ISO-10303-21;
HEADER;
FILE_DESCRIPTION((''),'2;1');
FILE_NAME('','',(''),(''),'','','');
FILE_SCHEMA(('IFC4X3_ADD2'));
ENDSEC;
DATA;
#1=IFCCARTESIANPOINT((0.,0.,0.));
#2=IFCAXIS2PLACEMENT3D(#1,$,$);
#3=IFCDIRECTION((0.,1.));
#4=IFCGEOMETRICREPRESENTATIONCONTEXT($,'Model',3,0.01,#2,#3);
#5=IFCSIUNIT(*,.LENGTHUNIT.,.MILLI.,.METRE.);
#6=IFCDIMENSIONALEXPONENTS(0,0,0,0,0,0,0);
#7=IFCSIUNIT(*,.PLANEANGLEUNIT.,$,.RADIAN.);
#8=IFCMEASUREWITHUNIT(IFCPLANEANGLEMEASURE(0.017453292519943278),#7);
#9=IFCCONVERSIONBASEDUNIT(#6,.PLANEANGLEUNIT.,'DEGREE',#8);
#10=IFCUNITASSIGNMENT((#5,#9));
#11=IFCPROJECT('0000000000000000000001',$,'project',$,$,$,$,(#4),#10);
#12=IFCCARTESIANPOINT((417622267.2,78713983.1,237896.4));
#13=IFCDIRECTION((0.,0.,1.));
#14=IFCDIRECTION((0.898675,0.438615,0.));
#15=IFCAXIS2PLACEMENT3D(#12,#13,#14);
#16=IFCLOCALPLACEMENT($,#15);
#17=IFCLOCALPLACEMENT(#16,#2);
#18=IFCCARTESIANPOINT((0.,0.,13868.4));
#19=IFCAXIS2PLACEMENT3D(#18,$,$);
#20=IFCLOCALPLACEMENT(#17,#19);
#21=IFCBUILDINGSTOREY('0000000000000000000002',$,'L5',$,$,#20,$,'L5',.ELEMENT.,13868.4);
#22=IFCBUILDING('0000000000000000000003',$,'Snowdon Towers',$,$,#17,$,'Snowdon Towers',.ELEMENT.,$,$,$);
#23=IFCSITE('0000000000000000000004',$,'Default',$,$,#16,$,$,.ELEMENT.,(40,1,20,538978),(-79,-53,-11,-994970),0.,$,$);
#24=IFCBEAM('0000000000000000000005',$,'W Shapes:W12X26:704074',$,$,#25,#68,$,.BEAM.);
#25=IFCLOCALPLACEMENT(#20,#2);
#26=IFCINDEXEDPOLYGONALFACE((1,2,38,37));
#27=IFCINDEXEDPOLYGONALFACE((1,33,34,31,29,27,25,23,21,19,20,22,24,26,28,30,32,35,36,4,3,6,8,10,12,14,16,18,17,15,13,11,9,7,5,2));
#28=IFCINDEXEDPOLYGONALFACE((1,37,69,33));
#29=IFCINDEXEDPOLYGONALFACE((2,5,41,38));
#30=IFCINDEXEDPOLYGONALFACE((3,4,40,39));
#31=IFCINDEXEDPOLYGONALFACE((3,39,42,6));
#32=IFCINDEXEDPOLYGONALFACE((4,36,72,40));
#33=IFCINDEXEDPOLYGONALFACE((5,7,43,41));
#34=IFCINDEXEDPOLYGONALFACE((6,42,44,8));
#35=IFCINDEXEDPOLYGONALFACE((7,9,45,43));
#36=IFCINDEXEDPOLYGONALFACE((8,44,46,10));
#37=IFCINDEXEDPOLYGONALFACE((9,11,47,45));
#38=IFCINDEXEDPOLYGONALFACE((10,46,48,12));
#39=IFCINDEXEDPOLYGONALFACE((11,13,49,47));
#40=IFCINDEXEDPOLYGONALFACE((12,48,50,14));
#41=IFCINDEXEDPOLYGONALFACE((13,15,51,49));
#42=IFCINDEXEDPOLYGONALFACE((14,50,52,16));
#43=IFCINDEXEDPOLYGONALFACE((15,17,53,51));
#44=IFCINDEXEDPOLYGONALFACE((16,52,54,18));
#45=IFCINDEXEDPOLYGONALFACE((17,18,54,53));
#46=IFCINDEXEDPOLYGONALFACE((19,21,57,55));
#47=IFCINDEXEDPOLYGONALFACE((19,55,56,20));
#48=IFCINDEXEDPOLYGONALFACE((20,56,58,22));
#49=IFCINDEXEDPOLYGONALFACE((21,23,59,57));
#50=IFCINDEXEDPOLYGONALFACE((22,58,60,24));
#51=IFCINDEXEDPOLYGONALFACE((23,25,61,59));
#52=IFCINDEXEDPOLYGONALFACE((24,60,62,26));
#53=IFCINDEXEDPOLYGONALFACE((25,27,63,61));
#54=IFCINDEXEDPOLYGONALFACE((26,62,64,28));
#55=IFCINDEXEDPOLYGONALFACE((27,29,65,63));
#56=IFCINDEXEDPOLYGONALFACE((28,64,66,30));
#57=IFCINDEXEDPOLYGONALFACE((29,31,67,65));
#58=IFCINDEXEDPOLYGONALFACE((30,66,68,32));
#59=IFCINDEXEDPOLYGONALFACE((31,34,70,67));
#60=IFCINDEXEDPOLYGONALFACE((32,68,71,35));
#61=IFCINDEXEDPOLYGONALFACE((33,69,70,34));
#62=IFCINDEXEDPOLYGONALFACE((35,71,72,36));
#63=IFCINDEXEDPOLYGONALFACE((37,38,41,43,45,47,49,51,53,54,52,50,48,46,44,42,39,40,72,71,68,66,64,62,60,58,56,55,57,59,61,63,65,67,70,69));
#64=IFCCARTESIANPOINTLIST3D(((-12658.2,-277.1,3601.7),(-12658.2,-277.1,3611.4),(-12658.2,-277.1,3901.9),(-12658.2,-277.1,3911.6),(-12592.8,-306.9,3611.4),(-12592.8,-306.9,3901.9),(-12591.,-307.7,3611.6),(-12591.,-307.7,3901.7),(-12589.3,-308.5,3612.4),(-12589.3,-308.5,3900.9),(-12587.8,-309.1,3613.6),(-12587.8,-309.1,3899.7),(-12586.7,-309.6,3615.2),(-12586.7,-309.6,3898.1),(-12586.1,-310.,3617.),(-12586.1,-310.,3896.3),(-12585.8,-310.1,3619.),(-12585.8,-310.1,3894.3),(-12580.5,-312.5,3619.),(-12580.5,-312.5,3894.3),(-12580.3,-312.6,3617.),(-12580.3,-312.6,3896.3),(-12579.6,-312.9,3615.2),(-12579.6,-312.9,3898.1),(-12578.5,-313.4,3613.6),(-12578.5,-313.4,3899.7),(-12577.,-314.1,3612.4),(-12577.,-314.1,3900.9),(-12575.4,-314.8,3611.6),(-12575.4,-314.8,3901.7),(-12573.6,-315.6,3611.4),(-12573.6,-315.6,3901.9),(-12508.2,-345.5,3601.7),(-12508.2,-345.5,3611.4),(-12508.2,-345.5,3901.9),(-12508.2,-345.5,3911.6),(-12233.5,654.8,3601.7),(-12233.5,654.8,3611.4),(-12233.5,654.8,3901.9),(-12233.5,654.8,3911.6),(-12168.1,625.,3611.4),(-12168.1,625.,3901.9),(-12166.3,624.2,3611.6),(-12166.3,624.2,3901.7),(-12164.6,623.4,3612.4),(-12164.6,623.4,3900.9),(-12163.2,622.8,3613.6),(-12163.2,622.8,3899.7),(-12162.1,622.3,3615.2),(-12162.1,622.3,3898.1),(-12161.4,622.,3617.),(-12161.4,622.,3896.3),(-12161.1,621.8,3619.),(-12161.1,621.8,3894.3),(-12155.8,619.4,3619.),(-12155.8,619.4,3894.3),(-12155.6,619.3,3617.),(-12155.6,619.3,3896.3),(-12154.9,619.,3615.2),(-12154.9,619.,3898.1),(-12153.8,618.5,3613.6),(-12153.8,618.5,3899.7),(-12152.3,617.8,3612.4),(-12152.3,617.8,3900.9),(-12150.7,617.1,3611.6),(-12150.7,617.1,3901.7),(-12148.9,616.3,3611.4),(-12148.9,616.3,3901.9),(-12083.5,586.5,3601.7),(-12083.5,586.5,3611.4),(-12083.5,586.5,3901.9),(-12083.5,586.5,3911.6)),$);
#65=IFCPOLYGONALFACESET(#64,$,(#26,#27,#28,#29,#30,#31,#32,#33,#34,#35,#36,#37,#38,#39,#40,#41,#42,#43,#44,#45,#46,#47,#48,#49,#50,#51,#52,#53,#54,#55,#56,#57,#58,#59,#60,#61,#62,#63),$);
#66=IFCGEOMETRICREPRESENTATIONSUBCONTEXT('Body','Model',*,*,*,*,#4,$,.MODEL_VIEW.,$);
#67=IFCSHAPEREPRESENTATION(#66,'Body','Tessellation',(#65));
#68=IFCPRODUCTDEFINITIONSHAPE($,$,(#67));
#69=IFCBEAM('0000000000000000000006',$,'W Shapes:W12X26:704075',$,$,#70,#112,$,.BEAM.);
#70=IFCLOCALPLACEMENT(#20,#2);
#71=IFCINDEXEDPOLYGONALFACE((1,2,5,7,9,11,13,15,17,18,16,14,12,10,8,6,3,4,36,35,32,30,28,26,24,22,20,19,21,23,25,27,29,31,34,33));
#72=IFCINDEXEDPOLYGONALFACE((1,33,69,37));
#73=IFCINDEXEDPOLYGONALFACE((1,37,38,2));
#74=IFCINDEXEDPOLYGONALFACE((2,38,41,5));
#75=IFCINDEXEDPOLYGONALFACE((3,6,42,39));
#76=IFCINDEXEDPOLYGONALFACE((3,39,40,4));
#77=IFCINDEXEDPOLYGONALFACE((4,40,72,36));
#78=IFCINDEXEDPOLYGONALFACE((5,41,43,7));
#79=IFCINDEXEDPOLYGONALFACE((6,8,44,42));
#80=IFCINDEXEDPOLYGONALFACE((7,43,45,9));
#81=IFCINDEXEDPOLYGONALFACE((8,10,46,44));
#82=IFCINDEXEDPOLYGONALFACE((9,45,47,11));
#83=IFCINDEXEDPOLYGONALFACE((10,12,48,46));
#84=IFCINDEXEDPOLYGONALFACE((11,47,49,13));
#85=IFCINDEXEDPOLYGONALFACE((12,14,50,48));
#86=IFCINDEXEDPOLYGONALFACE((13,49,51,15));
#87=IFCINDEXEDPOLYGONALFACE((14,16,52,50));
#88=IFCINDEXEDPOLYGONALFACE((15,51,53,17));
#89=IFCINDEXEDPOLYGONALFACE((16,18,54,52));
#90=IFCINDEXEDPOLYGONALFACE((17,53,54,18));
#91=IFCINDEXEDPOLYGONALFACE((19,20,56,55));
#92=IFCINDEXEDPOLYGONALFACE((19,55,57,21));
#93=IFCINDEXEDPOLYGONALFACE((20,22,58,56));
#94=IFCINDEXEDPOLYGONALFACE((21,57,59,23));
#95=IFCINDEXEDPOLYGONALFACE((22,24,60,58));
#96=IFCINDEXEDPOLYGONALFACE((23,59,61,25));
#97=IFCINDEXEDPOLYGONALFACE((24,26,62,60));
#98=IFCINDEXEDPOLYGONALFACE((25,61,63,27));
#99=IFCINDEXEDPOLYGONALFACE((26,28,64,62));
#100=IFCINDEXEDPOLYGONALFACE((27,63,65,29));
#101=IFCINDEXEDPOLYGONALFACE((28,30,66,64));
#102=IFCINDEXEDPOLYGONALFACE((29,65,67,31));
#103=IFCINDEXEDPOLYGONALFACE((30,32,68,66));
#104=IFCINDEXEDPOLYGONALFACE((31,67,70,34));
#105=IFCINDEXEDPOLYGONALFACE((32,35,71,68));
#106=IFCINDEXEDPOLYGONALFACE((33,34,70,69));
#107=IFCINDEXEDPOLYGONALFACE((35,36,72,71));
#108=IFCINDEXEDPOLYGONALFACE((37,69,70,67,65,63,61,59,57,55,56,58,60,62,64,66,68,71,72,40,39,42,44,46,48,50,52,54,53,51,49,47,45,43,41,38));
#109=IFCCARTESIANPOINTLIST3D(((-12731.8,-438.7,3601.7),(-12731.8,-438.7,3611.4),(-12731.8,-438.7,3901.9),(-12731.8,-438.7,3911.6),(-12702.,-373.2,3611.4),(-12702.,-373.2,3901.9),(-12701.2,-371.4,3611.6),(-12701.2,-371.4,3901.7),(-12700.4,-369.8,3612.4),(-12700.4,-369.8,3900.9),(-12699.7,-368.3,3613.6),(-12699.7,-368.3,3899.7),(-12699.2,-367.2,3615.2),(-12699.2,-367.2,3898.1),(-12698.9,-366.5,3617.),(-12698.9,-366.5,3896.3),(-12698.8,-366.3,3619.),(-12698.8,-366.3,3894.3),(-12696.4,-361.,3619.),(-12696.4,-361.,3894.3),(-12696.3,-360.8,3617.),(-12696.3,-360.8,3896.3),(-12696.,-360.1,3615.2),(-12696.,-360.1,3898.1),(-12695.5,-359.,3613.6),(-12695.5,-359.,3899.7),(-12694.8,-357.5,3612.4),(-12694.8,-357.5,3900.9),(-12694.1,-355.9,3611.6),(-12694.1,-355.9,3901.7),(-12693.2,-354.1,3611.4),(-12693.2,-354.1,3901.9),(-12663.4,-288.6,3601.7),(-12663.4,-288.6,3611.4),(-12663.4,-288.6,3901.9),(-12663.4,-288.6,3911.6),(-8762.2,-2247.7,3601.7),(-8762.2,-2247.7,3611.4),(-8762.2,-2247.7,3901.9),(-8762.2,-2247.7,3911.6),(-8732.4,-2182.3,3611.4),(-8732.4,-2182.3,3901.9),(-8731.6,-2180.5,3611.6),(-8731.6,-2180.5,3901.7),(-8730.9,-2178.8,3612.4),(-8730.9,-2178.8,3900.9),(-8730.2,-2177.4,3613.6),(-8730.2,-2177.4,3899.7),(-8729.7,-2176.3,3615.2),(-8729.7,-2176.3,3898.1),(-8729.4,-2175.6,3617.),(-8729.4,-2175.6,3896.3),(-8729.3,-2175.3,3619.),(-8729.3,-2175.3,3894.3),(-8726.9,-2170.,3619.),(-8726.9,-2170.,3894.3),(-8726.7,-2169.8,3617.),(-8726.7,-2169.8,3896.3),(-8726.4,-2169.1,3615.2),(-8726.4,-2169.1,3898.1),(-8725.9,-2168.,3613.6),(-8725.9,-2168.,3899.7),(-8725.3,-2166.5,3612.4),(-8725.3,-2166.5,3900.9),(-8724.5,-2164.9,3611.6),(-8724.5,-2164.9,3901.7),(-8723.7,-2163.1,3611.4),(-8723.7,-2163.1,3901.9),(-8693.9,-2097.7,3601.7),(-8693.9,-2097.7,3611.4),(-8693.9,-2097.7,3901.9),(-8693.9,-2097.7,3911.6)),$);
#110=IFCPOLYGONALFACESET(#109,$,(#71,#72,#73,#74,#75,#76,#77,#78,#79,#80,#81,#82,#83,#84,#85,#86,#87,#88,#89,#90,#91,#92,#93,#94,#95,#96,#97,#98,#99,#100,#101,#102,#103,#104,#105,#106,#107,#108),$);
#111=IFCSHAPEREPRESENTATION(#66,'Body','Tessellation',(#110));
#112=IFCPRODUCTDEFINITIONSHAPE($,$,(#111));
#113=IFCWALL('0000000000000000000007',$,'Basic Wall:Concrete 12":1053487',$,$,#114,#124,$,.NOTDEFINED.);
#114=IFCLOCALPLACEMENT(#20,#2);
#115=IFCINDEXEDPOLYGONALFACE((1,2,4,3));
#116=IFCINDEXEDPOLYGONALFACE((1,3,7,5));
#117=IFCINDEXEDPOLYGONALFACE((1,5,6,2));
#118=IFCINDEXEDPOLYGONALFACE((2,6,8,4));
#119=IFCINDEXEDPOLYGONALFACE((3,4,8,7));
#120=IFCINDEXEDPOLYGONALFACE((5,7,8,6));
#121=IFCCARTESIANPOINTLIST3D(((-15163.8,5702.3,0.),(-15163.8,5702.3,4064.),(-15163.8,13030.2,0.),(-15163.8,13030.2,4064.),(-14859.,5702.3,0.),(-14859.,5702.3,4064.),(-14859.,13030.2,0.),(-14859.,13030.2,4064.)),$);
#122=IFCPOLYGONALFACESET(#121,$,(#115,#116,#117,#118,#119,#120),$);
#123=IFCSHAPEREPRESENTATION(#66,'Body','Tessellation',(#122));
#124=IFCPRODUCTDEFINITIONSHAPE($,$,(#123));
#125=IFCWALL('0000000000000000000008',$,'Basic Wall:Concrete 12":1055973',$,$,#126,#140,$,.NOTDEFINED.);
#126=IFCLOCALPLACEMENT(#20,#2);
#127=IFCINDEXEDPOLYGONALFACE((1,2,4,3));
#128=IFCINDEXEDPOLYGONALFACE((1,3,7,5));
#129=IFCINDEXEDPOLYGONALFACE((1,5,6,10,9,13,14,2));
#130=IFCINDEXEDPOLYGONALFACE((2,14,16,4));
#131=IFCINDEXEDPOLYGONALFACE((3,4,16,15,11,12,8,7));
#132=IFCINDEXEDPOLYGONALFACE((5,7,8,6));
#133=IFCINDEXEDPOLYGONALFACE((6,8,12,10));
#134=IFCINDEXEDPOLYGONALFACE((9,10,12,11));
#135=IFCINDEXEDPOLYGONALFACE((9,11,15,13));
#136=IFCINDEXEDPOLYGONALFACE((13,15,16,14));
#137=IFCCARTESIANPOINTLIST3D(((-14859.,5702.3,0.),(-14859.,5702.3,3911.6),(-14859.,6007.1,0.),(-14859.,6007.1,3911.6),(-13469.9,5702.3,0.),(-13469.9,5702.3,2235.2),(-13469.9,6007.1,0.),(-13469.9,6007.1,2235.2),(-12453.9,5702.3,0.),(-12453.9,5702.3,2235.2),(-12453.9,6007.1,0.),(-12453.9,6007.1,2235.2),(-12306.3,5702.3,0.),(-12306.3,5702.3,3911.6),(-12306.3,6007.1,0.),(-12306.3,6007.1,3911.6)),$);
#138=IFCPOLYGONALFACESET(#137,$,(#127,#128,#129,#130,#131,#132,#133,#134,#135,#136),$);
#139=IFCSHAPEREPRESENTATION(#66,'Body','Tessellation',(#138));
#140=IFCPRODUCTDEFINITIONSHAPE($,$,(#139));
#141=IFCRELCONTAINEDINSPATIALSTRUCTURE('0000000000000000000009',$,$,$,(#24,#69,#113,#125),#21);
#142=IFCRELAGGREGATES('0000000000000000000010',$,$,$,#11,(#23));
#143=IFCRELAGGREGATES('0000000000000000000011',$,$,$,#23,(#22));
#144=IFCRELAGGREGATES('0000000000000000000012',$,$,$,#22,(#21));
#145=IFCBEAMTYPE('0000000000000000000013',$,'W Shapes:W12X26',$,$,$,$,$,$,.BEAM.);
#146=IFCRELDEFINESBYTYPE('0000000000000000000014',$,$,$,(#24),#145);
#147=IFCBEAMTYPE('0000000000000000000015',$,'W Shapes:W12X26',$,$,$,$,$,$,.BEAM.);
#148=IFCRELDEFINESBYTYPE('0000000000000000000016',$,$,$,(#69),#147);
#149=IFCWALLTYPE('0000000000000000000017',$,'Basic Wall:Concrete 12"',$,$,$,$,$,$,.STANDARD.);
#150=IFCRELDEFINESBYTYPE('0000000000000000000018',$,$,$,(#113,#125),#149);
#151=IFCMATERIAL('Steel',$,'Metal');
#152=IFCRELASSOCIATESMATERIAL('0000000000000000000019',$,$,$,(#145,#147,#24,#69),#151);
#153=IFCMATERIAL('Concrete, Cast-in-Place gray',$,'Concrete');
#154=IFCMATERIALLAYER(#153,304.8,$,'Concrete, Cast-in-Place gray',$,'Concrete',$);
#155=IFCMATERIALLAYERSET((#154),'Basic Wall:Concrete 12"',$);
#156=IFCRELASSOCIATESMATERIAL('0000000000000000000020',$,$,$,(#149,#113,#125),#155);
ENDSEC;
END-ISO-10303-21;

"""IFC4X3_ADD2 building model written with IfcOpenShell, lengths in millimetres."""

from ifc_helpers import new_model, entity, si_unit, converted_unit, direction, frame, frame_2d, origin, place, context, subcontext, project, spatial, polyline, circle_curve, parameter, trimmed, segment, composite_curve, rectangle, outline, extrude, source, transform, mapped, material, layer, layer_set, material_profile, profile_set, profile_usage, type_object, type_shapes, element, save


model = new_model("IFC4X3_ADD2")

# Units and contexts
model_context = context("Model", 3, precision=0.01, world=origin(), true_north=direction((0.0, 1.0)))
body_context = subcontext(model_context, "Body", "Model", "MODEL_VIEW")
ifc_project = project(units=[si_unit("LENGTHUNIT", "METRE", prefix="MILLI"), converted_unit("PLANEANGLEUNIT", "DEGREE", entity("IfcPlaneAngleMeasure", 0.017453292519943278), si_unit("PLANEANGLEUNIT", "RADIAN"), dimensions=[0, 0, 0, 0, 0, 0, 0])], contexts=[model_context])

# Site, building, storey
site_placement = place(None, frame((417622267.2, 78713983.1, 237896.4), z_axis=(0.0, 0.0, 1.0), x_axis=(0.898675, 0.438615, 0.0)))
site = spatial("IfcSite", under=ifc_project, at=site_placement, Name="Default", CompositionType="ELEMENT", RefLatitude=(40, 1, 20, 538978), RefLongitude=(-79, -53, -11, -994970), RefElevation=0.0)
building_placement = place(site_placement, origin())
building = spatial("IfcBuilding", under=site, at=building_placement, Name="Snowdon Towers", LongName="Snowdon Towers", CompositionType="ELEMENT")
storey_placement = place(building_placement, frame((0.0, 0.0, 13868.4)))
storey = spatial("IfcBuildingStorey", under=building, at=storey_placement, Name="L5", LongName="L5", CompositionType="ELEMENT", Elevation=13868.4)

# Beams
ifc_material_1 = material(Name="Steel", Category="Metal")
ifc_material_profile_1 = material_profile(ifc_material_1, outline(composite_curve([segment(polyline([(-82.4, -145.3), (-82.4, -154.9)]), True, "CONTINUOUS"), segment(polyline([(-82.4, -154.9), (82.4, -154.9)]), True, "CONTINUOUS"), segment(polyline([(82.4, -154.9), (82.4, -145.3)]), True, "CONTINUOUS"), segment(polyline([(82.4, -145.3), (10.5, -145.3)]), True, "CONTINUOUS"), segment(trimmed(circle_curve(frame_2d((10.5, -137.7), x_axis=(1.0, 0.0)), 7.6), [parameter(180.0)], [parameter(270.0)], True, "PARAMETER"), False, "CONTINUOUS"), segment(polyline([(2.9, -137.7), (2.9, 137.7)]), True, "CONTINUOUS"), segment(trimmed(circle_curve(frame_2d((10.5, 137.7), x_axis=(1.0, 0.0)), 7.6), [parameter(90.0)], [parameter(180.0)], True, "PARAMETER"), False, "CONTINUOUS"), segment(polyline([(10.5, 145.3), (82.4, 145.3)]), True, "CONTINUOUS"), segment(polyline([(82.4, 145.3), (82.4, 154.9)]), True, "CONTINUOUS"), segment(polyline([(82.4, 154.9), (-82.4, 154.9)]), True, "CONTINUOUS"), segment(polyline([(-82.4, 154.9), (-82.4, 145.3)]), True, "CONTINUOUS"), segment(polyline([(-82.4, 145.3), (-10.5, 145.3)]), True, "CONTINUOUS"), segment(trimmed(circle_curve(frame_2d((-10.5, 137.7), x_axis=(1.0, 0.0)), 7.6), [parameter(360.0)], [parameter(90.0)], True, "PARAMETER"), False, "CONTINUOUS"), segment(polyline([(-2.9, 137.7), (-2.9, -137.7)]), True, "CONTINUOUS"), segment(trimmed(circle_curve(frame_2d((-10.5, -137.7), x_axis=(1.0, 0.0)), 7.6), [parameter(270.0)], [parameter(360.0)], True, "PARAMETER"), False, "CONTINUOUS"), segment(polyline([(-10.5, -145.3), (-82.4, -145.3)]), True, "CONTINUOUS")], self_intersect=False)), Name="W12X26")
ifc_profile_set_1 = profile_set([ifc_material_profile_1], Name="W12X26")
ifc_profile_usage_1 = profile_usage(ifc_profile_set_1, cardinal=8)
beam_type_1 = type_object("IfcBeamType", Name="W Shapes:W12X26", PredefinedType="BEAM", material=ifc_profile_set_1)
shared_shape_1 = source(origin(), body_context, "Body", "SweptSolid", [
    extrude(outline(composite_curve([segment(polyline([(-82.4, -145.3), (-82.4, -154.9)]), True, "CONTINUOUS"), segment(polyline([(-82.4, -154.9), (82.4, -154.9)]), True, "CONTINUOUS"), segment(polyline([(82.4, -154.9), (82.4, -145.3)]), True, "CONTINUOUS"), segment(polyline([(82.4, -145.3), (10.5, -145.3)]), True, "CONTINUOUS"), segment(trimmed(circle_curve(frame_2d((10.5, -137.7), x_axis=(1.0, 0.0)), 7.6), [parameter(180.0)], [parameter(270.0)], True, "PARAMETER"), False, "CONTINUOUS"), segment(polyline([(2.9, -137.7), (2.9, 137.7)]), True, "CONTINUOUS"), segment(trimmed(circle_curve(frame_2d((10.5, 137.7), x_axis=(1.0, 0.0)), 7.6), [parameter(90.0)], [parameter(180.0)], True, "PARAMETER"), False, "CONTINUOUS"), segment(polyline([(10.5, 145.3), (82.4, 145.3)]), True, "CONTINUOUS"), segment(polyline([(82.4, 145.3), (82.4, 154.9)]), True, "CONTINUOUS"), segment(polyline([(82.4, 154.9), (-82.4, 154.9)]), True, "CONTINUOUS"), segment(polyline([(-82.4, 154.9), (-82.4, 145.3)]), True, "CONTINUOUS"), segment(polyline([(-82.4, 145.3), (-10.5, 145.3)]), True, "CONTINUOUS"), segment(trimmed(circle_curve(frame_2d((-10.5, 137.7), x_axis=(1.0, 0.0)), 7.6), [parameter(360.0)], [parameter(90.0)], True, "PARAMETER"), False, "CONTINUOUS"), segment(polyline([(-2.9, 137.7), (-2.9, -137.7)]), True, "CONTINUOUS"), segment(trimmed(circle_curve(frame_2d((-10.5, -137.7), x_axis=(1.0, 0.0)), 7.6), [parameter(270.0)], [parameter(360.0)], True, "PARAMETER"), False, "CONTINUOUS"), segment(polyline([(-10.5, -145.3), (-82.4, -145.3)]), True, "CONTINUOUS")], self_intersect=False)), frame((-542.2, 0.0, 0.0), z_axis=(-1.0, 0.0, 0.0), x_axis=(0.0, -1.0, 0.0)), (0.0, 0.0, -1.0), 1024.1),
])
type_shapes(beam_type_1, [shared_shape_1])
beam_1_placement = place(storey_placement, frame((-12358.3, 182.1, 3756.7), z_axis=(0.0, 0.0, 1.0), x_axis=(0.414693, 0.909961, 0.0)))
element("IfcBeam", 1, at=beam_1_placement, inside=storey, type_object=beam_type_1, material=ifc_profile_usage_1, Name="W Shapes:W12X26:704074", PredefinedType="BEAM", context=body_context, shape_type="MappedRepresentation", body=[
    mapped(shared_shape_1, transform((0.0, 0.0, 0.0), scale=1.0)),
])
beam_type_2 = type_object("IfcBeamType", Name="W Shapes:W12X26", PredefinedType="BEAM", material=ifc_profile_set_1)
shared_shape_2 = source(origin(), body_context, "Body", "SweptSolid", [
    extrude(outline(composite_curve([segment(polyline([(-82.4, -145.3), (-82.4, -154.9)]), True, "CONTINUOUS"), segment(polyline([(-82.4, -154.9), (82.4, -154.9)]), True, "CONTINUOUS"), segment(polyline([(82.4, -154.9), (82.4, -145.3)]), True, "CONTINUOUS"), segment(polyline([(82.4, -145.3), (10.5, -145.3)]), True, "CONTINUOUS"), segment(trimmed(circle_curve(frame_2d((10.5, -137.7), x_axis=(1.0, 0.0)), 7.6), [parameter(180.0)], [parameter(270.0)], True, "PARAMETER"), False, "CONTINUOUS"), segment(polyline([(2.9, -137.7), (2.9, 137.7)]), True, "CONTINUOUS"), segment(trimmed(circle_curve(frame_2d((10.5, 137.7), x_axis=(1.0, 0.0)), 7.6), [parameter(90.0)], [parameter(180.0)], True, "PARAMETER"), False, "CONTINUOUS"), segment(polyline([(10.5, 145.3), (82.4, 145.3)]), True, "CONTINUOUS"), segment(polyline([(82.4, 145.3), (82.4, 154.9)]), True, "CONTINUOUS"), segment(polyline([(82.4, 154.9), (-82.4, 154.9)]), True, "CONTINUOUS"), segment(polyline([(-82.4, 154.9), (-82.4, 145.3)]), True, "CONTINUOUS"), segment(polyline([(-82.4, 145.3), (-10.5, 145.3)]), True, "CONTINUOUS"), segment(trimmed(circle_curve(frame_2d((-10.5, 137.7), x_axis=(1.0, 0.0)), 7.6), [parameter(360.0)], [parameter(90.0)], True, "PARAMETER"), False, "CONTINUOUS"), segment(polyline([(-2.9, 137.7), (-2.9, -137.7)]), True, "CONTINUOUS"), segment(trimmed(circle_curve(frame_2d((-10.5, -137.7), x_axis=(1.0, 0.0)), 7.6), [parameter(270.0)], [parameter(360.0)], True, "PARAMETER"), False, "CONTINUOUS"), segment(polyline([(-10.5, -145.3), (-82.4, -145.3)]), True, "CONTINUOUS")], self_intersect=False)), frame((-2279.5, 0.0, 0.0), z_axis=(-1.0, 0.0, 0.0), x_axis=(0.0, -1.0, 0.0)), (0.0, 0.0, -1.0), 4362.3),
])
type_shapes(beam_type_2, [shared_shape_2])
beam_2_placement = place(storey_placement, frame((-10623.3, -1309.0, 3756.7), z_axis=(0.0, 0.0, 1.0), x_axis=(0.909961, -0.414693, 0.0)))
element("IfcBeam", 2, at=beam_2_placement, inside=storey, type_object=beam_type_2, material=ifc_profile_usage_1, Name="W Shapes:W12X26:704075", PredefinedType="BEAM", context=body_context, shape_type="MappedRepresentation", body=[
    mapped(shared_shape_2, transform((0.0, 0.0, 0.0), scale=1.0)),
])

# Wall
ifc_material_2 = material(Name="Concrete, Cast-in-Place gray", Category="Concrete")
ifc_layer = layer(ifc_material_2, 304.8, Name="Concrete, Cast-in-Place gray", Category="Concrete")
ifc_layer_set = layer_set([ifc_layer], Name="Basic Wall:Concrete 12\"")
wall_type = type_object("IfcWallType", Name="Basic Wall:Concrete 12\"", PredefinedType="STANDARD", material=ifc_layer_set)
wall_1_placement = place(storey_placement, frame((-15011.4, 13030.2, 0.0), z_axis=(0.0, 0.0, 1.0), x_axis=(0.0, -1.0, 0.0)))
element("IfcWall", 3, at=wall_1_placement, inside=storey, type_object=wall_type, material=ifc_layer_set, Name="Basic Wall:Concrete 12\":1053487", PredefinedType="NOTDEFINED", context=body_context, shape_type="SweptSolid", body=[
    extrude(rectangle(XDim=7327.9, YDim=304.8, at=frame_2d((3664.0, 0.0), x_axis=(-1.0, 0.0))), origin(), (0.0, 0.0, 1.0), 4064.0),
])

# Wall, opening
wall_2_placement = place(storey_placement, frame((-12306.3, 5854.7, 0.0), z_axis=(0.0, 0.0, 1.0), x_axis=(-1.0, 0.0, 0.0)))
wall_2 = element("IfcWall", 4, at=wall_2_placement, inside=storey, type_object=wall_type, material=ifc_layer_set, Name="Basic Wall:Concrete 12\":1055973", PredefinedType="NOTDEFINED", context=body_context, shape_type="SweptSolid", body=[
    extrude(rectangle(XDim=2552.7, YDim=304.8, at=frame_2d((1276.3, 0.0), x_axis=(-1.0, 0.0))), origin(), (0.0, 0.0, 1.0), 3911.6),
])
opening_placement = place(wall_2_placement, origin())
element("IfcOpeningElement", 5, at=opening_placement, cuts=wall_2, PredefinedType="OPENING", context=body_context, shape_type="SweptSolid", body=[
    extrude(rectangle(XDim=2235.2, YDim=1016.0, at=frame_2d((0.0, 0.0), x_axis=(0.0, 1.0))), frame((655.6, 152.4, 1117.6), z_axis=(0.0, -1.0, 0.0), x_axis=(1.0, 0.0, 0.0)), (0.0, 0.0, 1.0), 304.8),
])

save(model, "model.ifc")
